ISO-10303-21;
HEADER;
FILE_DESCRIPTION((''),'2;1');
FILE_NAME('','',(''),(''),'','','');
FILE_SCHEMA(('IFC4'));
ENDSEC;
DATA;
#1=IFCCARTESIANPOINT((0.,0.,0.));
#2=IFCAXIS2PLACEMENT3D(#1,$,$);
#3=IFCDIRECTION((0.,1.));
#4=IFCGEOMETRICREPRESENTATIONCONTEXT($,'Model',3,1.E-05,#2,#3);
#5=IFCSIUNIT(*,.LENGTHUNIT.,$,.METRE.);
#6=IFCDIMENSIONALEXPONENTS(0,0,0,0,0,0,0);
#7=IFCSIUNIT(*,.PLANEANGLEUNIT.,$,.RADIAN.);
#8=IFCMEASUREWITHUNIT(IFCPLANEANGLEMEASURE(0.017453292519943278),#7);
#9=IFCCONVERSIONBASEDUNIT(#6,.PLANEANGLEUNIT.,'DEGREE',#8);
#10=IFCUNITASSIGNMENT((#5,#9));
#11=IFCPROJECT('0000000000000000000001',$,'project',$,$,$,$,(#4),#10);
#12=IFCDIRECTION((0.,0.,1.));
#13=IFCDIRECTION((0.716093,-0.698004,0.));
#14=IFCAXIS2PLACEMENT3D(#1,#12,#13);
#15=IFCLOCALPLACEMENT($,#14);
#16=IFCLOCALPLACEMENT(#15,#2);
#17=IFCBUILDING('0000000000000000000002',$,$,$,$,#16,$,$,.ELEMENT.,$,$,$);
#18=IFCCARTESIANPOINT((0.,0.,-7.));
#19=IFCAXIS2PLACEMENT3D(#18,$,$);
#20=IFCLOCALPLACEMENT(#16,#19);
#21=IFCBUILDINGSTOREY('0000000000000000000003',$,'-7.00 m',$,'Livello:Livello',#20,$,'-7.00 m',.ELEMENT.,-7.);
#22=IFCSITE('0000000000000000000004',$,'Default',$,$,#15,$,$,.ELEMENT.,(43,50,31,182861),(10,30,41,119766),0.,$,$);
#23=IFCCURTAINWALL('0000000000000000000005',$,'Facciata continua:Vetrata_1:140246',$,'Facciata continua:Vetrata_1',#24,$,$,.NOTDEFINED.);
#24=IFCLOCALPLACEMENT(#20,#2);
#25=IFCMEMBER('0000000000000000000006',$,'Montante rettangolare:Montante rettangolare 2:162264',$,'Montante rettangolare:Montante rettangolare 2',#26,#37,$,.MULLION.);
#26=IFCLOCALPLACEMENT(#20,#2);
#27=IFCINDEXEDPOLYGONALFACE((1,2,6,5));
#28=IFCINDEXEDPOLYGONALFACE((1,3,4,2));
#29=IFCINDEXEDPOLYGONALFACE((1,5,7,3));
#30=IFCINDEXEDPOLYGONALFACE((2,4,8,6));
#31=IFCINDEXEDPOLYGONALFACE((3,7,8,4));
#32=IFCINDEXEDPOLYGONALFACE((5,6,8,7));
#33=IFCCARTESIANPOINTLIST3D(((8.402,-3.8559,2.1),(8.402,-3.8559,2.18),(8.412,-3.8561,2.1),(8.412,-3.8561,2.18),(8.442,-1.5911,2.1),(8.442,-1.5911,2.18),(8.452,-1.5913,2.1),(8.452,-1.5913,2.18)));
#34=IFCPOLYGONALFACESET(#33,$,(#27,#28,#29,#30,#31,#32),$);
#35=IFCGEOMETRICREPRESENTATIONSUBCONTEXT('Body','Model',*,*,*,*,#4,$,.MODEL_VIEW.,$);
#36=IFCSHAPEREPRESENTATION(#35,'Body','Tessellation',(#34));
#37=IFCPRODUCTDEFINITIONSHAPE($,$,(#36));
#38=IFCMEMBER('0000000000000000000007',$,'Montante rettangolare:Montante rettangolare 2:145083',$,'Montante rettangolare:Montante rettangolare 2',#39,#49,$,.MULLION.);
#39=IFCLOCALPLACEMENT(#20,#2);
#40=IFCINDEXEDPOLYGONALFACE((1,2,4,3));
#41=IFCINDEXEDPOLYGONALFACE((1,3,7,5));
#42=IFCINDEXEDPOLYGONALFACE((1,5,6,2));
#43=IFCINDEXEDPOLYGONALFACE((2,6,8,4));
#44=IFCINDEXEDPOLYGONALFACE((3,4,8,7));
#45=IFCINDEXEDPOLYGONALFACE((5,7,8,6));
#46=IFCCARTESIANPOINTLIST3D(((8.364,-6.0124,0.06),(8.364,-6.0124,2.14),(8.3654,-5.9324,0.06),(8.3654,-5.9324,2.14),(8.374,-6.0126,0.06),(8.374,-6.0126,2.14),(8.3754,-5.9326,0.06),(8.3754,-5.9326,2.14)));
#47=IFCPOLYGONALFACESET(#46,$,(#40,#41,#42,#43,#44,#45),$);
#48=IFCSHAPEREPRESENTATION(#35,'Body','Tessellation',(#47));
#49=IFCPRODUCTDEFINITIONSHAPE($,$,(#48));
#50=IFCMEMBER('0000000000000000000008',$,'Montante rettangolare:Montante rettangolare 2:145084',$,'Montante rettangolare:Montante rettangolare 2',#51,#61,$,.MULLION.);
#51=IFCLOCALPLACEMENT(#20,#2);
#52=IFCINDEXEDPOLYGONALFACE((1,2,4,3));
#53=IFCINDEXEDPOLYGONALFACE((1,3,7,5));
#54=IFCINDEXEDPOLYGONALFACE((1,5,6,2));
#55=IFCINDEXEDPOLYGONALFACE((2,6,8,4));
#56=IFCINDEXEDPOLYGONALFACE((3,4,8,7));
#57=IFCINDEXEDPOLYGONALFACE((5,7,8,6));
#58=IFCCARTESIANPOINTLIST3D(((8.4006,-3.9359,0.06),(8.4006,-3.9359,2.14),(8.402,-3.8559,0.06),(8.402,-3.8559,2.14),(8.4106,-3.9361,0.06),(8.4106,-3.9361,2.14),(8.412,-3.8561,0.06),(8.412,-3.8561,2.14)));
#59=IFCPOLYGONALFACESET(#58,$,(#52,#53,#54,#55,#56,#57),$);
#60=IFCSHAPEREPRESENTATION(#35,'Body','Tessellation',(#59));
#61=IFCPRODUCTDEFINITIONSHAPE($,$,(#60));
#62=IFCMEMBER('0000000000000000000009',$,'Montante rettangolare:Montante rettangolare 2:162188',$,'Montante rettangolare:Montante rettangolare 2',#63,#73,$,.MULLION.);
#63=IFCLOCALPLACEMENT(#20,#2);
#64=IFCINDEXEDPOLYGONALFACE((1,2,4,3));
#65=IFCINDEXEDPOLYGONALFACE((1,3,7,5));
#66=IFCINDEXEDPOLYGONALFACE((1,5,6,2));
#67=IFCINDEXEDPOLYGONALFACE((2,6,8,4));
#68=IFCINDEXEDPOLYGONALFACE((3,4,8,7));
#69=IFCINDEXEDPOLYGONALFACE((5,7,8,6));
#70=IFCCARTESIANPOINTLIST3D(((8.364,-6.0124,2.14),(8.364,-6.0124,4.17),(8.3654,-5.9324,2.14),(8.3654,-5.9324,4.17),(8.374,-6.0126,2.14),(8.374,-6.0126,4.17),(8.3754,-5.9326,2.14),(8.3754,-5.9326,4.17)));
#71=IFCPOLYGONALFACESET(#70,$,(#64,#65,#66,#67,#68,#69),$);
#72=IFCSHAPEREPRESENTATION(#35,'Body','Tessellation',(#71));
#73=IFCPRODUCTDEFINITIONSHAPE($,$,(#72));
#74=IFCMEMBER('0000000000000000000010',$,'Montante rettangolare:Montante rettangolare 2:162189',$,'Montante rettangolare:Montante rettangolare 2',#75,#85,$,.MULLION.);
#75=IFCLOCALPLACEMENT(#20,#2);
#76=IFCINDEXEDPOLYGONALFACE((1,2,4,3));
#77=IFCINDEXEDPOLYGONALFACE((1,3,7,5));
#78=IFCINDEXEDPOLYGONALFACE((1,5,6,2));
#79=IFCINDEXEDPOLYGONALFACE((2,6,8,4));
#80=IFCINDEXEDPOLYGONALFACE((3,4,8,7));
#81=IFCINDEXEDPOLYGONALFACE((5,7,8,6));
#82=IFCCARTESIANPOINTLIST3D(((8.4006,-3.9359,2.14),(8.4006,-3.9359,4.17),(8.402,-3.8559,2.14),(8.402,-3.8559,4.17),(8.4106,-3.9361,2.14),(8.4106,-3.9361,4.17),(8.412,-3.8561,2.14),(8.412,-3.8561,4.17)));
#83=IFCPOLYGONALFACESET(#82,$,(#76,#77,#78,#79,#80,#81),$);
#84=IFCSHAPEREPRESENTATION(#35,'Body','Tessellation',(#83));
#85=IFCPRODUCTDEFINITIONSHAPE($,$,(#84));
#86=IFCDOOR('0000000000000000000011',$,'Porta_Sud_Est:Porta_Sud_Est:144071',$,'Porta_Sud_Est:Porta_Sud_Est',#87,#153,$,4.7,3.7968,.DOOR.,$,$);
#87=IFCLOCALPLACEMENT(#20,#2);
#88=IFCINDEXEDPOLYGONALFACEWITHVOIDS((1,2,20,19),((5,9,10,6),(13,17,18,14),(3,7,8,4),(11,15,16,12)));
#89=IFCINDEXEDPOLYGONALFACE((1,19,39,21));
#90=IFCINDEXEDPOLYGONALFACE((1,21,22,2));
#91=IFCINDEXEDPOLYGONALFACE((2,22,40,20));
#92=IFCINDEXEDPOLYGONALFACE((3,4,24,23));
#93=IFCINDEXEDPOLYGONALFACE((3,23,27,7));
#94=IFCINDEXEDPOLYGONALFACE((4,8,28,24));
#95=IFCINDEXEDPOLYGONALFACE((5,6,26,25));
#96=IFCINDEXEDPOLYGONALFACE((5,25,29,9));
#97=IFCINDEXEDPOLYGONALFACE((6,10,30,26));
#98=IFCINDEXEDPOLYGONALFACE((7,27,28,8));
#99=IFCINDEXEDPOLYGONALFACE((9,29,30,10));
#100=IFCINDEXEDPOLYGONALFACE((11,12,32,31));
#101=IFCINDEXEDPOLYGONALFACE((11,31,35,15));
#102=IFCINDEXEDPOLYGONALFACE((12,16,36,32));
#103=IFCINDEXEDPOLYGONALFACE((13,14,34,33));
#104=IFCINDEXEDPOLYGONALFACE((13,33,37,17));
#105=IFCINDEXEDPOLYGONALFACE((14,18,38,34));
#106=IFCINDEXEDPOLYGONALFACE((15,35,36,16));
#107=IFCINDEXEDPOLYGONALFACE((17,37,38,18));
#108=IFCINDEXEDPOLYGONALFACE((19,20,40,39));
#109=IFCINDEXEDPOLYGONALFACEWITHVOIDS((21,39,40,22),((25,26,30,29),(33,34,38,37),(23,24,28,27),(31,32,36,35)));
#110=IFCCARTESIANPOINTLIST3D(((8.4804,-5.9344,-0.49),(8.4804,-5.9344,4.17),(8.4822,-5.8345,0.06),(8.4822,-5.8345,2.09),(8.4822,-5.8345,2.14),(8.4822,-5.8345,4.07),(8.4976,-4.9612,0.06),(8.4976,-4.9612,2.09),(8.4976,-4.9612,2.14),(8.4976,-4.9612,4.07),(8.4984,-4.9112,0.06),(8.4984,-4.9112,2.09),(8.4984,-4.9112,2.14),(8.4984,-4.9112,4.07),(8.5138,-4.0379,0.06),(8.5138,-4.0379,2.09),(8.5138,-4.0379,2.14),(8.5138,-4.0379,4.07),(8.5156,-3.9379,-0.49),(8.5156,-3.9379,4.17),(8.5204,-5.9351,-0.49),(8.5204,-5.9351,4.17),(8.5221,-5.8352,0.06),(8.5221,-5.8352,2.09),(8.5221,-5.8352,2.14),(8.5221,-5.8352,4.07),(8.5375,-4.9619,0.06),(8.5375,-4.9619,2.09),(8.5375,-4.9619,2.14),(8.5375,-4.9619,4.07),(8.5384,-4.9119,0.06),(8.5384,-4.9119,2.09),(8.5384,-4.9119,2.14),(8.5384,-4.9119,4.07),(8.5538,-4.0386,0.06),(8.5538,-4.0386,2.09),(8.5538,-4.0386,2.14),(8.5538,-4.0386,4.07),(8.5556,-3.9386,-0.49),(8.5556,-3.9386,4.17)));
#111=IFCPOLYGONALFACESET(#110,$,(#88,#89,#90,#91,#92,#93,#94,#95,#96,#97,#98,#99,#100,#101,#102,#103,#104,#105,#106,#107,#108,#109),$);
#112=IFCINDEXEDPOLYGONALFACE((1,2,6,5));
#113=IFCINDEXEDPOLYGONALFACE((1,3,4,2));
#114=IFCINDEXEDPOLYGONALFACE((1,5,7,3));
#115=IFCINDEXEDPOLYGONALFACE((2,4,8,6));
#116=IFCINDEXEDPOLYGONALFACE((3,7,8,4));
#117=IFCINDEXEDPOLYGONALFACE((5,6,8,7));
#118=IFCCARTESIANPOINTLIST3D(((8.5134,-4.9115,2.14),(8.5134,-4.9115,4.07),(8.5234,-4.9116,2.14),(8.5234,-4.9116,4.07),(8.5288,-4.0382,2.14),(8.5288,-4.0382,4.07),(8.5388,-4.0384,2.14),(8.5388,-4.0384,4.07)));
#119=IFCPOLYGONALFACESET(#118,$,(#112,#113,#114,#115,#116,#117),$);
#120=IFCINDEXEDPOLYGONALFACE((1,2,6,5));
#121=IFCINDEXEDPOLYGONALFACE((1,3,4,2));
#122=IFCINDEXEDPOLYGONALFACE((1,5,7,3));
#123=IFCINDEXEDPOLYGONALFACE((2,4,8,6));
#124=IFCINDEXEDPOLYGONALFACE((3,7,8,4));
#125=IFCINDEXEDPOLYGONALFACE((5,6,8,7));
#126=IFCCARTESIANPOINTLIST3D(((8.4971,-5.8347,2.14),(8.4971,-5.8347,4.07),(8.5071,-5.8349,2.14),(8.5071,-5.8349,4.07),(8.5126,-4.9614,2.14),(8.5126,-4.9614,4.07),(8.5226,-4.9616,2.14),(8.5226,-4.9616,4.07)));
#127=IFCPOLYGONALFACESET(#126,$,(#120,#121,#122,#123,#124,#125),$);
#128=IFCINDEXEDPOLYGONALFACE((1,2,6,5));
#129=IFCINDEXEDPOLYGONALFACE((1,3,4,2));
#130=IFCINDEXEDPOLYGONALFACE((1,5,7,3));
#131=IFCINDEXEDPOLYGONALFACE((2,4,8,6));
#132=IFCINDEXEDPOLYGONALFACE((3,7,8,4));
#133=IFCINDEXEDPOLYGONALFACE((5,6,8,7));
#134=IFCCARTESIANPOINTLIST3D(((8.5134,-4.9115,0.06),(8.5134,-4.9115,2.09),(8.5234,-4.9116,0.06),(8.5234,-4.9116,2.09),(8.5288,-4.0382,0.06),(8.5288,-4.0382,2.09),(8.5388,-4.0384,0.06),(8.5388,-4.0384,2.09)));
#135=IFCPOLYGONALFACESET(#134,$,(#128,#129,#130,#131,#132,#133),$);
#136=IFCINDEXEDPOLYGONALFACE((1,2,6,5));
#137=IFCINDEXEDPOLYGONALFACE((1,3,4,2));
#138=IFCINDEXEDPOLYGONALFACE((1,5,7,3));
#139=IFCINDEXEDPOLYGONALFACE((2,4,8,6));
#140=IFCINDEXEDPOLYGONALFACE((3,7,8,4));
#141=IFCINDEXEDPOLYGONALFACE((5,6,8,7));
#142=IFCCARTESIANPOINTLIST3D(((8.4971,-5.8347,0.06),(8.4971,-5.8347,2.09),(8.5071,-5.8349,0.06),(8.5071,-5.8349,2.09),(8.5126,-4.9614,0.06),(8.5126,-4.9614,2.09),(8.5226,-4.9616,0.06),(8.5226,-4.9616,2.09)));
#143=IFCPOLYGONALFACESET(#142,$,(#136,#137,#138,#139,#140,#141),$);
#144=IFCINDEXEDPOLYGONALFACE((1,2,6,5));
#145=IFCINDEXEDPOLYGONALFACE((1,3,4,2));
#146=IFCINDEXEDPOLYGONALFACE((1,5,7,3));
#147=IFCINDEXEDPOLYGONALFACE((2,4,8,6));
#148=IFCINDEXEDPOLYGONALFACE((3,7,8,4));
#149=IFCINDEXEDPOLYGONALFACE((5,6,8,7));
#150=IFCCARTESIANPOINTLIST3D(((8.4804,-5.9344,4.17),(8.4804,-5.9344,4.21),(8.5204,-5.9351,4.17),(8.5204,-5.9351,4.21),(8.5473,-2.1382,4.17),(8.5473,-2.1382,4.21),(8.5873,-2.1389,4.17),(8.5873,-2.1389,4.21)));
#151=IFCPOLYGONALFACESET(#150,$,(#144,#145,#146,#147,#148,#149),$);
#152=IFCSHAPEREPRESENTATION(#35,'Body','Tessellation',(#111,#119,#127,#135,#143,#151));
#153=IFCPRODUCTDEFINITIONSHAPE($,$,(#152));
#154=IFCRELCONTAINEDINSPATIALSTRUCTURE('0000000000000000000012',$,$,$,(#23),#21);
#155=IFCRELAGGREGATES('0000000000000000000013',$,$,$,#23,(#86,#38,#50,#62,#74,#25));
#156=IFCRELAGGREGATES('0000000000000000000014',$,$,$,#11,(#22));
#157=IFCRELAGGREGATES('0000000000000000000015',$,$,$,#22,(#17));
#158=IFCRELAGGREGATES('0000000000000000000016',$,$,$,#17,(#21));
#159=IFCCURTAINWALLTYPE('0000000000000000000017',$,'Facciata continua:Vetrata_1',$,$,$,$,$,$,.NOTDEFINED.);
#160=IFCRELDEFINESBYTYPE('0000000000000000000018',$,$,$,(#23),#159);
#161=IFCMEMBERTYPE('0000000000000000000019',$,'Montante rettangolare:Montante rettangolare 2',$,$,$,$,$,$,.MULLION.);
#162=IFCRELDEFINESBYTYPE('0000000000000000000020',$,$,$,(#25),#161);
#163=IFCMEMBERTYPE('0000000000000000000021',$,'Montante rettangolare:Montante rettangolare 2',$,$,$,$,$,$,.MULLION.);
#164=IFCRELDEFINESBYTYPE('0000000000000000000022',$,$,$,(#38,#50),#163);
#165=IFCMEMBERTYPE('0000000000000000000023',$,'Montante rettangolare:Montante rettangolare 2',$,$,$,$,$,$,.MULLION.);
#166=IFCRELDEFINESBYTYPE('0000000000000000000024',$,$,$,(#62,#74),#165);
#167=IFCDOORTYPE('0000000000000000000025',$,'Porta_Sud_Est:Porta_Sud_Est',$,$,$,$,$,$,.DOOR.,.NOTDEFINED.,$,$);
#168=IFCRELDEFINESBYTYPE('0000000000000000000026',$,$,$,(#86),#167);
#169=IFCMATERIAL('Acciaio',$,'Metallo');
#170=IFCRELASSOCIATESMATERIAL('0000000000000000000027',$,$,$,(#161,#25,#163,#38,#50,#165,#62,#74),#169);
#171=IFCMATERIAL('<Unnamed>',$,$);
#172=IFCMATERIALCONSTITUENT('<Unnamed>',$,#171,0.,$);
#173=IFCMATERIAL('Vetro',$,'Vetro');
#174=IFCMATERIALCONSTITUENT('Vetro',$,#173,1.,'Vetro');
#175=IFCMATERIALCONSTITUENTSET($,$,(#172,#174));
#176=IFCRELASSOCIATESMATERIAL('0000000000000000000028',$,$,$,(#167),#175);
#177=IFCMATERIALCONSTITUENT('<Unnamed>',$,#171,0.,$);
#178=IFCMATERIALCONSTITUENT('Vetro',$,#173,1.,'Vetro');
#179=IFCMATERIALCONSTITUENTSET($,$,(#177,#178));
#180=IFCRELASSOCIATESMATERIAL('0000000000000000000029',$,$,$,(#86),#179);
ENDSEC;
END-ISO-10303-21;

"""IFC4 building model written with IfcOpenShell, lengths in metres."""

from ifc_helpers import new_model, entity, si_unit, converted_unit, direction, frame, origin, place, context, subcontext, project, spatial, indexed_curve, outline, extrude, source, transform, mapped, material, constituent, constituent_set, type_object, type_shapes, element, aggregate, save


model = new_model("IFC4")

# Units and contexts
model_context = context("Model", 3, precision=1e-05, world=origin(), true_north=direction((0.0, 1.0)))
body_context = subcontext(model_context, "Body", "Model", "MODEL_VIEW")
ifc_project = project(units=[si_unit("LENGTHUNIT", "METRE"), converted_unit("PLANEANGLEUNIT", "DEGREE", entity("IfcPlaneAngleMeasure", 0.017453292519943278), si_unit("PLANEANGLEUNIT", "RADIAN"), dimensions=[0, 0, 0, 0, 0, 0, 0])], contexts=[model_context])

# Site, building, storey
site_placement = place(None, frame((0.0, 0.0, 0.0), z_axis=(0.0, 0.0, 1.0), x_axis=(0.716093, -0.698004, 0.0)))
site = spatial("IfcSite", under=ifc_project, at=site_placement, Name="Default", CompositionType="ELEMENT", RefLatitude=(43, 50, 31, 182861), RefLongitude=(10, 30, 41, 119766), RefElevation=0.0)
building_placement = place(site_placement, origin())
building = spatial("IfcBuilding", under=site, at=building_placement, CompositionType="ELEMENT")
storey_placement = place(building_placement, frame((0.0, 0.0, -7.0)))
storey = spatial("IfcBuildingStorey", under=building, at=storey_placement, Name="-7.00 m", ObjectType="Livello:Livello", LongName="-7.00 m", CompositionType="ELEMENT", Elevation=-7.0)

# Shared definitions
ifc_material_1 = material(Name="Acciaio", Category="Metallo")

# Curtain wall
curtain_wall_type_1 = type_object("IfcCurtainWallType", Name="Facciata continua:Vetrata_1", PredefinedType="NOTDEFINED")
curtain_wall_1_placement = place(storey_placement, frame((0.0, 0.0, 7.0)))
curtain_wall_1 = element("IfcCurtainWall", 1, at=curtain_wall_1_placement, inside=storey, type_object=curtain_wall_type_1, Name="Facciata continua:Vetrata_1:140246", ObjectType="Facciata continua:Vetrata_1", PredefinedType="NOTDEFINED")

# Members
member_type_1 = type_object("IfcMemberType", Name="Montante rettangolare:Montante rettangolare 2", PredefinedType="MULLION", material=ifc_material_1)
shared_shape_1 = source(origin(), body_context, "Body", "SweptSolid", [
    extrude(outline(indexed_curve([(-0.04, -0.005), (0.04, -0.005), (0.04, 0.005), (-0.04, 0.005), (-0.04, -0.005)], self_intersect=False)), frame((0.0, 0.01, -2.2652), z_axis=(0.0, 0.0, 1.0), x_axis=(-1.0, 0.0, 0.0)), (0.0, 0.0, 1.0), 2.2652),
])
type_shapes(member_type_1, [shared_shape_1])
member_1_placement = place(curtain_wall_1_placement, frame((8.437, -1.591, -4.86), z_axis=(0.017636, 0.999844, 0.0), x_axis=(0.0, 0.0, 1.0)))
member_1 = element("IfcMember", 2, at=member_1_placement, type_object=member_type_1, material=ifc_material_1, Name="Montante rettangolare:Montante rettangolare 2:162264", ObjectType="Montante rettangolare:Montante rettangolare 2", PredefinedType="MULLION", context=body_context, shape_type="MappedRepresentation", body=[
    mapped(shared_shape_1, transform((0.0, 0.0, 0.0), scale=1.0)),
])
member_type_2 = type_object("IfcMemberType", Name="Montante rettangolare:Montante rettangolare 2", PredefinedType="MULLION", material=ifc_material_1)
shared_shape_2 = source(origin(), body_context, "Body", "SweptSolid", [
    extrude(outline(indexed_curve([(-0.04, -0.005), (0.04, -0.005), (0.04, 0.005), (-0.04, 0.005), (-0.04, -0.005)], self_intersect=False)), frame((0.0, 0.01, -2.08), z_axis=(0.0, 0.0, 1.0), x_axis=(-1.0, 0.0, 0.0)), (0.0, 0.0, 1.0), 2.08),
])
type_shapes(member_type_2, [shared_shape_2])
member_2_placement = place(curtain_wall_1_placement, frame((8.3597, -5.9723, -6.94), z_axis=(0.0, 0.0, -1.0), x_axis=(0.017636, 0.999844, 0.0)))
member_2 = element("IfcMember", 3, at=member_2_placement, type_object=member_type_2, material=ifc_material_1, Name="Montante rettangolare:Montante rettangolare 2:145083", ObjectType="Montante rettangolare:Montante rettangolare 2", PredefinedType="MULLION", context=body_context, shape_type="MappedRepresentation", body=[
    mapped(shared_shape_2, transform((0.0, 0.0, 0.0), scale=1.0)),
])
member_3_placement = place(curtain_wall_1_placement, frame((8.3963, -3.8958, -6.94), z_axis=(0.0, 0.0, -1.0), x_axis=(0.017636, 0.999844, 0.0)))
member_3 = element("IfcMember", 4, at=member_3_placement, type_object=member_type_2, material=ifc_material_1, Name="Montante rettangolare:Montante rettangolare 2:145084", ObjectType="Montante rettangolare:Montante rettangolare 2", PredefinedType="MULLION", context=body_context, shape_type="MappedRepresentation", body=[
    mapped(shared_shape_2, transform((0.0, 0.0, 0.0), scale=1.0)),
])
member_type_3 = type_object("IfcMemberType", Name="Montante rettangolare:Montante rettangolare 2", PredefinedType="MULLION", material=ifc_material_1)
shared_shape_3 = source(origin(), body_context, "Body", "SweptSolid", [
    extrude(outline(indexed_curve([(-0.04, -0.005), (0.04, -0.005), (0.04, 0.005), (-0.04, 0.005), (-0.04, -0.005)], self_intersect=False)), frame((0.0, 0.01, -2.03), z_axis=(0.0, 0.0, 1.0), x_axis=(-1.0, 0.0, 0.0)), (0.0, 0.0, 1.0), 2.03),
])
type_shapes(member_type_3, [shared_shape_3])
member_4_placement = place(curtain_wall_1_placement, frame((8.3597, -5.9723, -4.86), z_axis=(0.0, 0.0, -1.0), x_axis=(0.017636, 0.999844, 0.0)))
member_4 = element("IfcMember", 5, at=member_4_placement, type_object=member_type_3, material=ifc_material_1, Name="Montante rettangolare:Montante rettangolare 2:162188", ObjectType="Montante rettangolare:Montante rettangolare 2", PredefinedType="MULLION", context=body_context, shape_type="MappedRepresentation", body=[
    mapped(shared_shape_3, transform((0.0, 0.0, 0.0), scale=1.0)),
])
member_5_placement = place(curtain_wall_1_placement, frame((8.3963, -3.8958, -4.86), z_axis=(0.0, 0.0, -1.0), x_axis=(0.017636, 0.999844, 0.0)))
member_5 = element("IfcMember", 6, at=member_5_placement, type_object=member_type_3, material=ifc_material_1, Name="Montante rettangolare:Montante rettangolare 2:162189", ObjectType="Montante rettangolare:Montante rettangolare 2", PredefinedType="MULLION", context=body_context, shape_type="MappedRepresentation", body=[
    mapped(shared_shape_3, transform((0.0, 0.0, 0.0), scale=1.0)),
])

# Door
ifc_material_2 = material(Name="<Unnamed>")
ifc_constituent_1 = constituent(ifc_material_2, Name="<Unnamed>", fraction=0.0)
ifc_material_3 = material(Name="Vetro", Category="Vetro")
ifc_constituent_2 = constituent(ifc_material_3, Name="Vetro", Category="Vetro", fraction=1.0)
ifc_constituent_set_1 = constituent_set(constituents=[ifc_constituent_1, ifc_constituent_2])
ifc_constituent_3 = constituent(ifc_material_2, Name="<Unnamed>", fraction=0.0)
ifc_constituent_4 = constituent(ifc_material_3, Name="Vetro", Category="Vetro", fraction=1.0)
ifc_constituent_set_2 = constituent_set(constituents=[ifc_constituent_3, ifc_constituent_4])
door_type = type_object("IfcDoorType", Name="Porta_Sud_Est:Porta_Sud_Est", OperationType="NOTDEFINED", PredefinedType="DOOR", material=ifc_constituent_set_2)
shared_shape_4 = source(origin(), body_context, "Body", "SweptSolid", [
    extrude(outline(indexed_curve([(-0.9984, -2.33), (0.9984, -2.33), (0.9984, 2.33), (-0.9984, 2.33), (-0.9984, -2.33)], self_intersect=False), holes=[indexed_curve([(0.025, -0.3), (0.8984, -0.3), (0.8984, -2.23), (0.025, -2.23), (0.025, -0.3)], self_intersect=False), indexed_curve([(-0.8984, -0.3), (-0.025, -0.3), (-0.025, -2.23), (-0.8984, -2.23), (-0.8984, -0.3)], self_intersect=False), indexed_curve([(0.025, -0.25), (0.025, 1.78), (0.8984, 1.78), (0.8984, -0.25), (0.025, -0.25)], self_intersect=False), indexed_curve([(-0.025, 1.78), (-0.025, -0.25), (-0.8984, -0.25), (-0.8984, 1.78), (-0.025, 1.78)], self_intersect=False)]), frame((0.0, -0.16, 1.78), z_axis=(0.0, 1.0, 0.0), x_axis=(1.0, 0.0, 0.0)), (0.0, 0.0, 1.0), 0.04),
    extrude(outline(indexed_curve([(-0.4367, -0.005), (0.4367, -0.005), (0.4367, 0.005), (-0.4367, 0.005), (-0.4367, -0.005)], self_intersect=False)), frame((0.4617, -0.14, 2.08), z_axis=(0.0, 0.0, 1.0), x_axis=(-1.0, 0.0, 0.0)), (0.0, 0.0, 1.0), 1.93),
    extrude(outline(indexed_curve([(-0.4367, -0.005), (0.4367, -0.005), (0.4367, 0.005), (-0.4367, 0.005), (-0.4367, -0.005)], self_intersect=False)), frame((-0.4617, -0.14, 2.08), z_axis=(0.0, 0.0, 1.0), x_axis=(-1.0, 0.0, 0.0)), (0.0, 0.0, 1.0), 1.93),
    extrude(outline(indexed_curve([(-0.4367, -0.005), (0.4367, -0.005), (0.4367, 0.005), (-0.4367, 0.005), (-0.4367, -0.005)], self_intersect=False)), frame((0.4617, -0.14, 0.0), z_axis=(0.0, 0.0, 1.0), x_axis=(-1.0, 0.0, 0.0)), (0.0, 0.0, 1.0), 2.03),
    extrude(outline(indexed_curve([(-0.4367, -0.005), (0.4367, -0.005), (0.4367, 0.005), (-0.4367, 0.005), (-0.4367, -0.005)], self_intersect=False)), frame((-0.4617, -0.14, 0.0), z_axis=(0.0, 0.0, 1.0), x_axis=(-1.0, 0.0, 0.0)), (0.0, 0.0, 1.0), 2.03),
    extrude(outline(indexed_curve([(-1.8984, -0.02), (1.8984, -0.02), (1.8984, 0.02), (-1.8984, 0.02), (-1.8984, -0.02)], self_intersect=False)), frame((0.9, -0.14, 4.11), z_axis=(0.0, 0.0, 1.0), x_axis=(-1.0, 0.0, 0.0)), (0.0, 0.0, 1.0), 0.04),
])
type_shapes(door_type, [shared_shape_4])
door_placement = place(curtain_wall_1_placement, frame((8.378, -4.9341, -6.94), z_axis=(0.0, 0.0, 1.0), x_axis=(0.017636, 0.999844, 0.0)))
door = element("IfcDoor", 7, at=door_placement, type_object=door_type, material=ifc_constituent_set_1, Name="Porta_Sud_Est:Porta_Sud_Est:144071", ObjectType="Porta_Sud_Est:Porta_Sud_Est", OverallHeight=4.7, OverallWidth=3.7968, PredefinedType="DOOR", context=body_context, shape_type="MappedRepresentation", body=[
    mapped(shared_shape_4, transform((0.0, 0.0, 0.0), scale=1.0)),
])
aggregate(curtain_wall_1, [door, member_2, member_3, member_4, member_5, member_1])

save(model, "model.ifc")
